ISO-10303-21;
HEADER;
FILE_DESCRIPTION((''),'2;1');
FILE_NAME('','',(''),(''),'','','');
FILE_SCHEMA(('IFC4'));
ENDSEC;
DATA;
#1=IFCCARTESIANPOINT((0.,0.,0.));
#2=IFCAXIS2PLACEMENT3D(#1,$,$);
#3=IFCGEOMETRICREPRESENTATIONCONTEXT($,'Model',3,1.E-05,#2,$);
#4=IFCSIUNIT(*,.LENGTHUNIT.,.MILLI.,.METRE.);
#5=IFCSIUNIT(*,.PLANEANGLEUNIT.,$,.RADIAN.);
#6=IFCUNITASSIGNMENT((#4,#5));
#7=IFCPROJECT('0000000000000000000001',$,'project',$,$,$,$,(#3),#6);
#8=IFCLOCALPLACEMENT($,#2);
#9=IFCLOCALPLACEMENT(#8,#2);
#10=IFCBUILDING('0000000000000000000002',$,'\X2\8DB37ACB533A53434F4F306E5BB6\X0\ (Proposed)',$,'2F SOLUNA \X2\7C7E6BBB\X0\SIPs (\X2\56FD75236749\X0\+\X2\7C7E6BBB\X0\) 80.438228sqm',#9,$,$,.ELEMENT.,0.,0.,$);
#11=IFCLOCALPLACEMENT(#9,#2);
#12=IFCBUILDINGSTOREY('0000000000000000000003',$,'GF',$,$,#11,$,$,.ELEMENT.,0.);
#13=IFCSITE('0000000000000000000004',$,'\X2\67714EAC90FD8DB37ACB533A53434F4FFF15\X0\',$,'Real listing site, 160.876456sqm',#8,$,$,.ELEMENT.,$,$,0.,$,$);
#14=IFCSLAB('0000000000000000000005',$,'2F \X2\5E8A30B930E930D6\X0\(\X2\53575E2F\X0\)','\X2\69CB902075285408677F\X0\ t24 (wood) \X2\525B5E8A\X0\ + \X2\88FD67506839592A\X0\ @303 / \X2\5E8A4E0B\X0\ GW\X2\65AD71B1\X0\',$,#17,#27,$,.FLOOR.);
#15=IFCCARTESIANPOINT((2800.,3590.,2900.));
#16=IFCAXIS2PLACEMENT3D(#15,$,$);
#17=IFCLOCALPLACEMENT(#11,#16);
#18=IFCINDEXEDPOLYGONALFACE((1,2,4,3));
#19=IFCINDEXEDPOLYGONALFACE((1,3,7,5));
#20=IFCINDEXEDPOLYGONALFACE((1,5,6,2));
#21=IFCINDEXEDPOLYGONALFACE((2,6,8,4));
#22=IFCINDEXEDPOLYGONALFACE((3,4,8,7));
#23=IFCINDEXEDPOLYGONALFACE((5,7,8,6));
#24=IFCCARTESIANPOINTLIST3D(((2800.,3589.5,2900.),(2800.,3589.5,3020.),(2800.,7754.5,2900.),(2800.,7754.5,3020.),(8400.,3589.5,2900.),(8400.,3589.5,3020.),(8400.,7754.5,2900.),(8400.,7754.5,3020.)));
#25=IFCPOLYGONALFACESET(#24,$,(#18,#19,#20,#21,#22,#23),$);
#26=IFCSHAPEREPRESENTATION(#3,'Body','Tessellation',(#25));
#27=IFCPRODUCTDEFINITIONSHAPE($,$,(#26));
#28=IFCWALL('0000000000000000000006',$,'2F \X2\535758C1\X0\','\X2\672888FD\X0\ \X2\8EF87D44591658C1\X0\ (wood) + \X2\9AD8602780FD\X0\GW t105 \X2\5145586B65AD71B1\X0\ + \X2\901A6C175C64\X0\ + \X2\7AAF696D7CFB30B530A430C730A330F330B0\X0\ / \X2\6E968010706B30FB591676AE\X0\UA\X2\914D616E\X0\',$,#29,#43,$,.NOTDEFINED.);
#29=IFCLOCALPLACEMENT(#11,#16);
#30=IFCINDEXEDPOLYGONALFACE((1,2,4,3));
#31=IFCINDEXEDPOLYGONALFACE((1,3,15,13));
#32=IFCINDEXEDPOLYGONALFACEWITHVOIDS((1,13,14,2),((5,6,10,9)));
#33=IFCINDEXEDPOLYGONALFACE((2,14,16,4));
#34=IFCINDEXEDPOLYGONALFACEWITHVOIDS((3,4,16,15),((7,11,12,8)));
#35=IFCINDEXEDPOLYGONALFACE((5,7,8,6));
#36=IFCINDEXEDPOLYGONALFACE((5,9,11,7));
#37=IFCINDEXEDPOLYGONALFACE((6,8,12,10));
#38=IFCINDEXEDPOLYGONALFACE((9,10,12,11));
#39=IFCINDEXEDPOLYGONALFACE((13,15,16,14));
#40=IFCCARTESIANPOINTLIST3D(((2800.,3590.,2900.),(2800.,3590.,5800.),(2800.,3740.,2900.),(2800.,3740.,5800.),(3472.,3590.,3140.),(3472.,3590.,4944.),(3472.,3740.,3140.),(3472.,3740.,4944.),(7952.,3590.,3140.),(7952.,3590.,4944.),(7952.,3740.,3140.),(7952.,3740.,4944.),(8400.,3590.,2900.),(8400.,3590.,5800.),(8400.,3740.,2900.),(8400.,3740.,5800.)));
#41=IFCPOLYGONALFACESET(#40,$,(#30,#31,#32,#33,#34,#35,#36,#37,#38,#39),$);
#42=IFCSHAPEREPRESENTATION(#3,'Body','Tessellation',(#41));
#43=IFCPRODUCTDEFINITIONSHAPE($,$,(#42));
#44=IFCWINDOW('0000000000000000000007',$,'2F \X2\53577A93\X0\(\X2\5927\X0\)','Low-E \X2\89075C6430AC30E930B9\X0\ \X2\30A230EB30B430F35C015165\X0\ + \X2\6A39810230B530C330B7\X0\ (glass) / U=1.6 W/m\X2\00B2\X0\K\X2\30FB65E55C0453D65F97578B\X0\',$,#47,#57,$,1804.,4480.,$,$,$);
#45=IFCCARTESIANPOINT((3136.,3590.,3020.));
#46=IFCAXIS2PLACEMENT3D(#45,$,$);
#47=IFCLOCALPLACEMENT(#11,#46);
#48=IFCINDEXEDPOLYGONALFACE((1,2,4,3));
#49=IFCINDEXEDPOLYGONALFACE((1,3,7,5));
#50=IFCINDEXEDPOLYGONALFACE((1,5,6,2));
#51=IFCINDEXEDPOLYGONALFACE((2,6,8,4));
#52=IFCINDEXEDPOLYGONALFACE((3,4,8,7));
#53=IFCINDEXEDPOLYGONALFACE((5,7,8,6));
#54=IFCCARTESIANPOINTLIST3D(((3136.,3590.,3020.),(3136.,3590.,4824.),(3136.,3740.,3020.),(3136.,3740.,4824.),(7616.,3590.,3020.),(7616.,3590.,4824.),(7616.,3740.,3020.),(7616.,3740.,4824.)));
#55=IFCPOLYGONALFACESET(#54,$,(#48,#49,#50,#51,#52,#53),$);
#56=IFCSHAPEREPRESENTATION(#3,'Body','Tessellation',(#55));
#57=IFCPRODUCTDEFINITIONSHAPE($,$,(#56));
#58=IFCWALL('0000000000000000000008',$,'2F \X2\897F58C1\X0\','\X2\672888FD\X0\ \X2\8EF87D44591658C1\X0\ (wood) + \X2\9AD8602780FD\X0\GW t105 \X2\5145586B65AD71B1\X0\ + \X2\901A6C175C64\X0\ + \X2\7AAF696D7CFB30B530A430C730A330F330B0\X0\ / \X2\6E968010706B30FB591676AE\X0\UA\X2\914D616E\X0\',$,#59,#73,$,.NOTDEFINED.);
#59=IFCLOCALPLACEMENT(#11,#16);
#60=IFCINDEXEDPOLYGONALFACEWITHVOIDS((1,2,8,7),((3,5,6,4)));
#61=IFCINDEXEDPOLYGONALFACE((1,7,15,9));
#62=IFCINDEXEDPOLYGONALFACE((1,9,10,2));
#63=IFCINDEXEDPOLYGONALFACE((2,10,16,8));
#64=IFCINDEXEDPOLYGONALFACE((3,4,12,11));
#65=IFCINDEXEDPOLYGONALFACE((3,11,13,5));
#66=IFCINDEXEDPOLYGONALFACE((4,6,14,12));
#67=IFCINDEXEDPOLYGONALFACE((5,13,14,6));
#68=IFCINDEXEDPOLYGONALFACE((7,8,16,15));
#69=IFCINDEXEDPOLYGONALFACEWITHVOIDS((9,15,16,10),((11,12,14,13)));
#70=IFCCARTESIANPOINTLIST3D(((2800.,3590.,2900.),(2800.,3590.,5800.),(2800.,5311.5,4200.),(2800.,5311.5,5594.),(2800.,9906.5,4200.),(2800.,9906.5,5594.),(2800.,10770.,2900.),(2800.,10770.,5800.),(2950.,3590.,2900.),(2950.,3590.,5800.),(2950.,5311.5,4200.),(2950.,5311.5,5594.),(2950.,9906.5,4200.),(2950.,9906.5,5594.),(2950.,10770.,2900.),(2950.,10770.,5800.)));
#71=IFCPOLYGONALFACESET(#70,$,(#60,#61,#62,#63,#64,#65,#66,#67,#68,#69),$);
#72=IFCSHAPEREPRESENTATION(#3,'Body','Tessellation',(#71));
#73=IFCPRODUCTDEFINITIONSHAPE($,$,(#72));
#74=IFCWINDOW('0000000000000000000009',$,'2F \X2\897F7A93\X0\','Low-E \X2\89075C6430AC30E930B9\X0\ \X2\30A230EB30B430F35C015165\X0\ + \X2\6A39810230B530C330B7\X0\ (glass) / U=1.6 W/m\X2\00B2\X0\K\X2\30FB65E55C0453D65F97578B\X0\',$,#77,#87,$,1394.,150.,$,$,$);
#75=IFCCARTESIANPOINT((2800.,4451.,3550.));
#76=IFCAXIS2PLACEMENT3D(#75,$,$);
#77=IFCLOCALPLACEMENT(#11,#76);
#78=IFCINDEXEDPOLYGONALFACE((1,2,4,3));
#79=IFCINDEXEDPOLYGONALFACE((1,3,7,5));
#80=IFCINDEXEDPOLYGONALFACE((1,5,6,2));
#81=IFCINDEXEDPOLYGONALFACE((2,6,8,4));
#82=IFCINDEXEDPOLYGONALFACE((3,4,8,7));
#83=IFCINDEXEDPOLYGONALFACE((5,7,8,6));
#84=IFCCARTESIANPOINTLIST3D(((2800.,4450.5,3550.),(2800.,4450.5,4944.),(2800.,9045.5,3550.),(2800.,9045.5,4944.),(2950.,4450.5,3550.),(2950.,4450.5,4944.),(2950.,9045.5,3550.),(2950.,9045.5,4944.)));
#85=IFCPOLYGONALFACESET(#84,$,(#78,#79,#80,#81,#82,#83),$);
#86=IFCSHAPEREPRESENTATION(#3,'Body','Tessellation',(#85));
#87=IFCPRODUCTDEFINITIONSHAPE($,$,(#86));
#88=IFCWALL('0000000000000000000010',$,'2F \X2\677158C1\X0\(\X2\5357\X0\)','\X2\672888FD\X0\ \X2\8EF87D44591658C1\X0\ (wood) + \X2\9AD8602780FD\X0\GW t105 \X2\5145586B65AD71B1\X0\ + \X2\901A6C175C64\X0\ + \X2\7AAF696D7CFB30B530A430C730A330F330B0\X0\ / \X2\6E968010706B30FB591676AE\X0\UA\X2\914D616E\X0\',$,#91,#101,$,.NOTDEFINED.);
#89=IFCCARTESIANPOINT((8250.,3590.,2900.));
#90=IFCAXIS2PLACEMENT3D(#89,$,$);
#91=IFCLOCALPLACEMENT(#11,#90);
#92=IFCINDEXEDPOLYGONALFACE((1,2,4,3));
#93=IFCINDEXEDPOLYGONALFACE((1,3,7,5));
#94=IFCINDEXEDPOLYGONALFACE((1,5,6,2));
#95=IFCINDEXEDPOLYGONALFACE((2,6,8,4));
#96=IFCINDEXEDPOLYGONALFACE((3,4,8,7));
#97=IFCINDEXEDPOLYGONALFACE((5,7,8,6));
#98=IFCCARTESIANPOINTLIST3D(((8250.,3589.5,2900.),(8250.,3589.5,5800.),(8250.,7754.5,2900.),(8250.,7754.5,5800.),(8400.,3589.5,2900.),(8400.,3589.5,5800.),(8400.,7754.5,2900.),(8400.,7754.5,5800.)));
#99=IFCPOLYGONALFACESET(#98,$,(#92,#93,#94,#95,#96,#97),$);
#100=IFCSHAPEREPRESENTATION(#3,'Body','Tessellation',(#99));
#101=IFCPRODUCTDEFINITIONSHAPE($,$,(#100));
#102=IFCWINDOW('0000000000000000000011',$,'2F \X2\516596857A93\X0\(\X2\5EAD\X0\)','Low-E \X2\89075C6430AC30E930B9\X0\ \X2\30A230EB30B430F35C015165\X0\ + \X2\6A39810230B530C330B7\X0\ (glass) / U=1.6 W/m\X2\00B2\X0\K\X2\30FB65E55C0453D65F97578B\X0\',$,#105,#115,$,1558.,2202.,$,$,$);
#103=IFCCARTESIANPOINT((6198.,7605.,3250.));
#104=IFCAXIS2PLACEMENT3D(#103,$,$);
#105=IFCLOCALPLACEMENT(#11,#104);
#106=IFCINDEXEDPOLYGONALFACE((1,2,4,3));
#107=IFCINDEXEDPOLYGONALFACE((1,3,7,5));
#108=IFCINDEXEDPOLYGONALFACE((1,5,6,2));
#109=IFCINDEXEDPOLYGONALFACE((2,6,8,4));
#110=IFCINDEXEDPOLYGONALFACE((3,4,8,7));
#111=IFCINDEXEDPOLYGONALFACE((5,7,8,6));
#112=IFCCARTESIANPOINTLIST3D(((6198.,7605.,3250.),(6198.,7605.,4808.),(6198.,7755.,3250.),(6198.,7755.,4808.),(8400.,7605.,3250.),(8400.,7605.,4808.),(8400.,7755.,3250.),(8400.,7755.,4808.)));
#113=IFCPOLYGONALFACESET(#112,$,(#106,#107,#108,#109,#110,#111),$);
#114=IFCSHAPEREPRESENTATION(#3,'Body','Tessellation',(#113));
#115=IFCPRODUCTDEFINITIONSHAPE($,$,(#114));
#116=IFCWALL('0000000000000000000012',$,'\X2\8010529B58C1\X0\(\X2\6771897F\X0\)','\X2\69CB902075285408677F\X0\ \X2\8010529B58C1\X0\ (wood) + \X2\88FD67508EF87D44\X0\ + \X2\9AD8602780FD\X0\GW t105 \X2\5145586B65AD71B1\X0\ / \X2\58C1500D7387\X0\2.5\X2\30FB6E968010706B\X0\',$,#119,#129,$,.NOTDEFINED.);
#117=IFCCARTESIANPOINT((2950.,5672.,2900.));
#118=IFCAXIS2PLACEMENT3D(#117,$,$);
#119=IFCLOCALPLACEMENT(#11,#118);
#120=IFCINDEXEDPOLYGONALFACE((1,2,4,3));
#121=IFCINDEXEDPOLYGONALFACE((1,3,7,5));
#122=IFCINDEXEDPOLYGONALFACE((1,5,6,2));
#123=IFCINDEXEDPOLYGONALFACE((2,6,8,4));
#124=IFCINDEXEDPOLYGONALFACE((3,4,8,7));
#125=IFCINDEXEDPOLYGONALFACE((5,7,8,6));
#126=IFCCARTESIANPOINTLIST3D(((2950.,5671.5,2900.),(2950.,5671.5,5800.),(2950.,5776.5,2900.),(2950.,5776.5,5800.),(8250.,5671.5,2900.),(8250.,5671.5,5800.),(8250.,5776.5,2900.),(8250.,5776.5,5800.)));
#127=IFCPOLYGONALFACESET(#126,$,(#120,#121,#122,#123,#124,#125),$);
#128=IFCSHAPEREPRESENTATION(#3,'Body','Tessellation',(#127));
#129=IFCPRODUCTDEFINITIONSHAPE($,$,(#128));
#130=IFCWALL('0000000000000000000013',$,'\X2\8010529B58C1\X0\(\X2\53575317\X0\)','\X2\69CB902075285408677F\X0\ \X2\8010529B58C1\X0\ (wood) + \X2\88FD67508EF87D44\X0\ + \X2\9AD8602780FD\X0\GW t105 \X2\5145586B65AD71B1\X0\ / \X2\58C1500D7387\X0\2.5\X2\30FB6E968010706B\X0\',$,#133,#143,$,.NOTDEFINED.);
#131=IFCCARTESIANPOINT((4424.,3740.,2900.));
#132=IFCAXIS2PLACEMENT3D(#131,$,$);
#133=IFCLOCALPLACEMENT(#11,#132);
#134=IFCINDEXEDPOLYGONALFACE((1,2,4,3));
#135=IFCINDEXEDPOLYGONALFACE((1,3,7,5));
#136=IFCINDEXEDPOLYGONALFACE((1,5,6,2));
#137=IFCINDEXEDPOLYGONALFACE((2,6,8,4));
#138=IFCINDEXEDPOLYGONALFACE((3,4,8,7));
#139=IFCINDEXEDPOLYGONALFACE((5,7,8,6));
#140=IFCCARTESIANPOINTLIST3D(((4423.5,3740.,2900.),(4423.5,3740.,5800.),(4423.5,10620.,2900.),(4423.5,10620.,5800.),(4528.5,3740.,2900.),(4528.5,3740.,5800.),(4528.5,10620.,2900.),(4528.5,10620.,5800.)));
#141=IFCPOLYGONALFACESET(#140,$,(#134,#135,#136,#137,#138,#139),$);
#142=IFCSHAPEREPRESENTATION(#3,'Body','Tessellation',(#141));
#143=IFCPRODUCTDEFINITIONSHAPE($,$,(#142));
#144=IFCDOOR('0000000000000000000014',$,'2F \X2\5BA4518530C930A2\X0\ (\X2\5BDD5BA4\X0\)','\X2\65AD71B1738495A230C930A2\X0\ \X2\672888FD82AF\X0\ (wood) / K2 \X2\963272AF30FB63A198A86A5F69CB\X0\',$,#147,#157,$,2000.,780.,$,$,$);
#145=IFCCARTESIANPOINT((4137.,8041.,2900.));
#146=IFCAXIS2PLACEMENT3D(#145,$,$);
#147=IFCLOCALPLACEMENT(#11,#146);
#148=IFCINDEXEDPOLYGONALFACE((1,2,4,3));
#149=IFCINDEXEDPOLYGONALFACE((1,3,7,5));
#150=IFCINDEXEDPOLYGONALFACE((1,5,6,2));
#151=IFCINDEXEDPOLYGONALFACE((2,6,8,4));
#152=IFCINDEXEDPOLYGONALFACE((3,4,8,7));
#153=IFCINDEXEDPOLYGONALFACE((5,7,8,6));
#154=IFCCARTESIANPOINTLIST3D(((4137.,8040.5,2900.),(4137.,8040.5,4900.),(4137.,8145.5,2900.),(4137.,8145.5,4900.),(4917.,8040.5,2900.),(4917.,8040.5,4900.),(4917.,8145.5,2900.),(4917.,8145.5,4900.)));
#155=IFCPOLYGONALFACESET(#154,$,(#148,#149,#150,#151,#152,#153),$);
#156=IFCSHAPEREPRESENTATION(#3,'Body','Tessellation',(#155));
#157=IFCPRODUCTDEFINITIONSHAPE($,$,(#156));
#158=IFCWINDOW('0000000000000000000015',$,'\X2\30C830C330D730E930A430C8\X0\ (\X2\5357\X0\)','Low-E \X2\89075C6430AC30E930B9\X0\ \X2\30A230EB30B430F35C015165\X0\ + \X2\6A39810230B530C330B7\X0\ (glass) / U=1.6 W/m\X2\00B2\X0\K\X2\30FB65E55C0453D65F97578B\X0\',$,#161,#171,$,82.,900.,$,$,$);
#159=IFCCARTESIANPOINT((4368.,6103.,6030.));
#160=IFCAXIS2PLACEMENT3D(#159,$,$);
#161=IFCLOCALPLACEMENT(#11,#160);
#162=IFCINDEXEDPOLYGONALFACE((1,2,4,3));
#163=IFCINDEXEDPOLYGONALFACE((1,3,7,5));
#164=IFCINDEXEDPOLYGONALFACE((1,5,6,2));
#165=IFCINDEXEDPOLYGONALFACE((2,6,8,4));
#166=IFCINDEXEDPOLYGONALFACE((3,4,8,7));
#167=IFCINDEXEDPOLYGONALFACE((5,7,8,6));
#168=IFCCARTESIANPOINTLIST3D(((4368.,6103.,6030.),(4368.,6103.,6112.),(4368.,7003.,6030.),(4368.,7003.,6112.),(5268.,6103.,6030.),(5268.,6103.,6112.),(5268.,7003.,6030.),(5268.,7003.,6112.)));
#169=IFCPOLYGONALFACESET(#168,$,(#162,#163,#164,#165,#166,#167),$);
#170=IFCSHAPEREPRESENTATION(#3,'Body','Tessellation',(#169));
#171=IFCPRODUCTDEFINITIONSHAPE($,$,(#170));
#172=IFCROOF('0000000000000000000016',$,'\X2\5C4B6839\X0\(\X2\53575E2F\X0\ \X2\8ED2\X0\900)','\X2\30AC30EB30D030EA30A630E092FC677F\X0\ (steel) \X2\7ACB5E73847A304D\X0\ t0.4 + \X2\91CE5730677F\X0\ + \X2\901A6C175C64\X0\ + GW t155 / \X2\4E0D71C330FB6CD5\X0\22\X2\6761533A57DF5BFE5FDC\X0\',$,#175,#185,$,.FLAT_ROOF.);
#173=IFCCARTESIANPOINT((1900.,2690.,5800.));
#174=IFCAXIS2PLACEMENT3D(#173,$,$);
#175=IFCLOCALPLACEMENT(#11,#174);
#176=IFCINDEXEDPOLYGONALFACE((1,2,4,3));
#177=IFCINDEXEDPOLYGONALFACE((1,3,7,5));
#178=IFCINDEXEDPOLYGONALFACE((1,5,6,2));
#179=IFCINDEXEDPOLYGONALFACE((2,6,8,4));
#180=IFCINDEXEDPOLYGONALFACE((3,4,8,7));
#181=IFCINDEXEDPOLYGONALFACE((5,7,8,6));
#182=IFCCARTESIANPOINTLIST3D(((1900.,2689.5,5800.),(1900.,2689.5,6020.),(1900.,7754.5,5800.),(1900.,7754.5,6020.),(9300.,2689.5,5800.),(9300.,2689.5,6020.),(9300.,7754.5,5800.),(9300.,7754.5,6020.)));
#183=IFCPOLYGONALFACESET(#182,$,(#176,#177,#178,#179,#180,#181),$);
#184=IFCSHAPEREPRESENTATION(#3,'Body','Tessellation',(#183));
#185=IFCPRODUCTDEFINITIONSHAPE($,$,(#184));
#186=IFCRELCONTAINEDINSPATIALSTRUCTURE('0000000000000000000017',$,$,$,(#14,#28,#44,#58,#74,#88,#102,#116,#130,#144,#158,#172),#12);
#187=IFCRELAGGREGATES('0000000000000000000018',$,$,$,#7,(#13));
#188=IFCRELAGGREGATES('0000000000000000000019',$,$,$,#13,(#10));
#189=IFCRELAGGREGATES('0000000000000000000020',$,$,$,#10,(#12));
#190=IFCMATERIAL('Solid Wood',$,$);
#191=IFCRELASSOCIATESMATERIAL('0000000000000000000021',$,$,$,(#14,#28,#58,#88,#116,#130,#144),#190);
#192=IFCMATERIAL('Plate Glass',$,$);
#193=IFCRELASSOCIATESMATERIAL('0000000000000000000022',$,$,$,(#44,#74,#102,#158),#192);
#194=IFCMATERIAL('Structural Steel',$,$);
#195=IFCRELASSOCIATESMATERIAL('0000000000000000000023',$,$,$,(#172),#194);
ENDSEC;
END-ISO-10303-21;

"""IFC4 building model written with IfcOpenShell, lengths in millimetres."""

from ifc_helpers import new_model, si_unit, frame, frame_2d, origin, place, context, project, spatial, rectangle, extrude, material, element, fill, save


model = new_model("IFC4")

# Units and contexts
model_context = context("Model", 3, precision=1e-05, world=origin())
ifc_project = project(units=[si_unit("LENGTHUNIT", "METRE", prefix="MILLI"), si_unit("PLANEANGLEUNIT", "RADIAN")], contexts=[model_context])

# Site, building, storey
site_placement = place(None, origin())
site = spatial("IfcSite", under=ifc_project, at=site_placement, Name="東京都足立区千住５", ObjectType="Real listing site, 160.876456sqm", CompositionType="ELEMENT", RefElevation=0.0)
building_placement = place(site_placement, origin())
building = spatial("IfcBuilding", under=site, at=building_placement, Name="足立区千住の家 (Proposed)", ObjectType="2F SOLUNA 籾殻SIPs (国産杉+籾殻) 80.438228sqm", CompositionType="ELEMENT", ElevationOfRefHeight=0.0, ElevationOfTerrain=0.0)
storey_placement = place(building_placement, origin())
storey = spatial("IfcBuildingStorey", under=building, at=storey_placement, Name="GF", CompositionType="ELEMENT", Elevation=0.0)

# Slab
ifc_material_1 = material(Name="Solid Wood")
slab_placement = place(storey_placement, frame((2800.0, 3590.0, 2900.0)))
element("IfcSlab", 1, at=slab_placement, inside=storey, material=ifc_material_1, Name="2F 床スラブ(南帯)", Description="構造用合板 t24 (wood) 剛床 + 製材根太 @303 / 床下 GW断熱", PredefinedType="FLOOR", context=model_context, shape_type="SweptSolid", body=[
    extrude(rectangle(XDim=5600.0, YDim=4165.0, at=frame_2d((2800.0, 2082.0))), frame((2800.0, 3590.0, 2900.0)), (0.0, 0.0, 1.0), 120.0),
])

# Walls, openings, windows
wall_1_placement = place(storey_placement, frame((2800.0, 3590.0, 2900.0)))
wall_1 = element("IfcWall", 2, at=wall_1_placement, inside=storey, material=ifc_material_1, Name="2F 南壁", Description="木製 軸組外壁 (wood) + 高性能GW t105 充填断熱 + 通気層 + 窯業系サイディング / 準耐火・外皮UA配慮", PredefinedType="NOTDEFINED", context=model_context, shape_type="SweptSolid", body=[
    extrude(rectangle(XDim=5600.0, YDim=150.0, at=frame_2d((2800.0, 75.0))), frame((2800.0, 3590.0, 2900.0)), (0.0, 0.0, 1.0), 2900.0),
])
opening_1_placement = place(storey_placement, frame((3136.0, 3590.0, 3020.0)))
opening_1 = element("IfcOpeningElement", 3, at=opening_1_placement, cuts=wall_1, PredefinedType="NOTDEFINED", context=model_context, shape_type="SweptSolid", body=[
    extrude(rectangle(XDim=4480.0, YDim=150.0, at=frame_2d((2240.0, 75.0))), frame((3136.0, 3590.0, 3020.0)), (0.0, 0.0, 1.0), 1804.0),
])
ifc_material_2 = material(Name="Plate Glass")
window_1_placement = place(storey_placement, frame((3136.0, 3590.0, 3020.0)))
window_1 = element("IfcWindow", 4, at=window_1_placement, inside=storey, material=ifc_material_2, Name="2F 南窓(大)", Description="Low-E 複層ガラス アルゴン封入 + 樹脂サッシ (glass) / U=1.6 W/m²K・日射取得型", OverallHeight=1804.0, OverallWidth=4480.0, context=model_context, shape_type="SweptSolid", body=[
    extrude(rectangle(XDim=4480.0, YDim=150.0, at=frame_2d((2240.0, 75.0))), frame((3136.0, 3590.0, 3020.0)), (0.0, 0.0, 1.0), 1804.0),
])
fill(opening_1, window_1)
wall_2_placement = place(storey_placement, frame((2800.0, 3590.0, 2900.0)))
wall_2 = element("IfcWall", 5, at=wall_2_placement, inside=storey, material=ifc_material_1, Name="2F 西壁", Description="木製 軸組外壁 (wood) + 高性能GW t105 充填断熱 + 通気層 + 窯業系サイディング / 準耐火・外皮UA配慮", PredefinedType="NOTDEFINED", context=model_context, shape_type="SweptSolid", body=[
    extrude(rectangle(XDim=150.0, YDim=7180.0, at=frame_2d((75.0, 3590.0))), frame((2800.0, 3590.0, 2900.0)), (0.0, 0.0, 1.0), 2900.0),
])
opening_2_placement = place(storey_placement, frame((2800.0, 4451.0, 3550.0)))
opening_2 = element("IfcOpeningElement", 6, at=opening_2_placement, cuts=wall_2, PredefinedType="NOTDEFINED", context=model_context, shape_type="SweptSolid", body=[
    extrude(rectangle(XDim=150.0, YDim=4595.0, at=frame_2d((75.0, 2297.0))), frame((2800.0, 4451.0, 3550.0)), (0.0, 0.0, 1.0), 1394.0),
])
window_2_placement = place(storey_placement, frame((2800.0, 4451.0, 3550.0)))
window_2 = element("IfcWindow", 7, at=window_2_placement, inside=storey, material=ifc_material_2, Name="2F 西窓", Description="Low-E 複層ガラス アルゴン封入 + 樹脂サッシ (glass) / U=1.6 W/m²K・日射取得型", OverallHeight=1394.0, OverallWidth=150.0, context=model_context, shape_type="SweptSolid", body=[
    extrude(rectangle(XDim=150.0, YDim=4595.0, at=frame_2d((75.0, 2297.0))), frame((2800.0, 4451.0, 3550.0)), (0.0, 0.0, 1.0), 1394.0),
])
fill(opening_2, window_2)
wall_3_placement = place(storey_placement, frame((8250.0, 3590.0, 2900.0)))
wall_3 = element("IfcWall", 8, at=wall_3_placement, inside=storey, material=ifc_material_1, Name="2F 東壁(南)", Description="木製 軸組外壁 (wood) + 高性能GW t105 充填断熱 + 通気層 + 窯業系サイディング / 準耐火・外皮UA配慮", PredefinedType="NOTDEFINED", context=model_context, shape_type="SweptSolid", body=[
    extrude(rectangle(XDim=150.0, YDim=4165.0, at=frame_2d((75.0, 2082.0))), frame((8250.0, 3590.0, 2900.0)), (0.0, 0.0, 1.0), 2900.0),
])
opening_3_placement = place(storey_placement, frame((6198.0, 7605.0, 3250.0)))
opening_3 = element("IfcOpeningElement", 9, at=opening_3_placement, cuts=wall_3, PredefinedType="NOTDEFINED", context=model_context, shape_type="SweptSolid", body=[
    extrude(rectangle(XDim=2202.0, YDim=150.0, at=frame_2d((1101.0, 75.0))), frame((6198.0, 7605.0, 3250.0)), (0.0, 0.0, 1.0), 1558.0),
])
window_3_placement = place(storey_placement, frame((6198.0, 7605.0, 3250.0)))
window_3 = element("IfcWindow", 10, at=window_3_placement, inside=storey, material=ifc_material_2, Name="2F 入隅窓(庭)", Description="Low-E 複層ガラス アルゴン封入 + 樹脂サッシ (glass) / U=1.6 W/m²K・日射取得型", OverallHeight=1558.0, OverallWidth=2202.0, context=model_context, shape_type="SweptSolid", body=[
    extrude(rectangle(XDim=2202.0, YDim=150.0, at=frame_2d((1101.0, 75.0))), frame((6198.0, 7605.0, 3250.0)), (0.0, 0.0, 1.0), 1558.0),
])
fill(opening_3, window_3)

# Wall
wall_4_placement = place(storey_placement, frame((2950.0, 5672.0, 2900.0)))
element("IfcWall", 11, at=wall_4_placement, inside=storey, material=ifc_material_1, Name="耐力壁(東西)", Description="構造用合板 耐力壁 (wood) + 製材軸組 + 高性能GW t105 充填断熱 / 壁倍率2.5・準耐火", PredefinedType="NOTDEFINED", context=model_context, shape_type="SweptSolid", body=[
    extrude(rectangle(XDim=5300.0, YDim=105.0, at=frame_2d((2650.0, 52.0))), frame((2950.0, 5672.0, 2900.0)), (0.0, 0.0, 1.0), 2900.0),
])

# Wall, opening, door
wall_5_placement = place(storey_placement, frame((4424.0, 3740.0, 2900.0)))
wall_5 = element("IfcWall", 12, at=wall_5_placement, inside=storey, material=ifc_material_1, Name="耐力壁(南北)", Description="構造用合板 耐力壁 (wood) + 製材軸組 + 高性能GW t105 充填断熱 / 壁倍率2.5・準耐火", PredefinedType="NOTDEFINED", context=model_context, shape_type="SweptSolid", body=[
    extrude(rectangle(XDim=105.0, YDim=6880.0, at=frame_2d((52.0, 3440.0))), frame((4424.0, 3740.0, 2900.0)), (0.0, 0.0, 1.0), 2900.0),
])
opening_4_placement = place(storey_placement, frame((4137.0, 8041.0, 2900.0)))
opening_4 = element("IfcOpeningElement", 13, at=opening_4_placement, cuts=wall_5, PredefinedType="NOTDEFINED", context=model_context, shape_type="SweptSolid", body=[
    extrude(rectangle(XDim=780.0, YDim=105.0, at=frame_2d((390.0, 52.0))), frame((4137.0, 8041.0, 2900.0)), (0.0, 0.0, 1.0), 2000.0),
])
door_placement = place(storey_placement, frame((4137.0, 8041.0, 2900.0)))
door = element("IfcDoor", 14, at=door_placement, inside=storey, material=ifc_material_1, Name="2F 室内ドア (寝室)", Description="断熱玄関ドア 木製芯 (wood) / K2 防犯・採風機構", OverallHeight=2000.0, OverallWidth=780.0, context=model_context, shape_type="SweptSolid", body=[
    extrude(rectangle(XDim=780.0, YDim=105.0, at=frame_2d((390.0, 52.0))), frame((4137.0, 8041.0, 2900.0)), (0.0, 0.0, 1.0), 2000.0),
])
fill(opening_4, door)

# Window
window_4_placement = place(storey_placement, frame((4368.0, 6103.0, 6030.0)))
element("IfcWindow", 15, at=window_4_placement, inside=storey, material=ifc_material_2, Name="トップライト (南)", Description="Low-E 複層ガラス アルゴン封入 + 樹脂サッシ (glass) / U=1.6 W/m²K・日射取得型", OverallHeight=82.0, OverallWidth=900.0, context=model_context, shape_type="SweptSolid", body=[
    extrude(rectangle(XDim=900.0, YDim=900.0, at=frame_2d((450.0, 450.0))), frame((4368.0, 6103.0, 6030.0)), (0.0, 0.0, 1.0), 82.0),
])

# Roof
ifc_material_3 = material(Name="Structural Steel")
for number, where, name in (
    (16, (1900.0, 2690.0, 5800.0), "屋根(南帯 軒900)"),
):
    element("IfcRoof", number, at=place(storey_placement, frame(where)), inside=storey, material=ifc_material_3, Name=name, Description="ガルバリウム鋼板 (steel) 立平葺き t0.4 + 野地板 + 通気層 + GW t155 / 不燃・法22条区域対応", PredefinedType="FLAT_ROOF", context=model_context, shape_type="SweptSolid", body=[
        extrude(rectangle(XDim=7400.0, YDim=5065.0, at=frame_2d((3700.0, 2532.0))), frame((1900.0, 2690.0, 5800.0)), (0.0, 0.0, 1.0), 220.0),
    ])

save(model, "model.ifc")
